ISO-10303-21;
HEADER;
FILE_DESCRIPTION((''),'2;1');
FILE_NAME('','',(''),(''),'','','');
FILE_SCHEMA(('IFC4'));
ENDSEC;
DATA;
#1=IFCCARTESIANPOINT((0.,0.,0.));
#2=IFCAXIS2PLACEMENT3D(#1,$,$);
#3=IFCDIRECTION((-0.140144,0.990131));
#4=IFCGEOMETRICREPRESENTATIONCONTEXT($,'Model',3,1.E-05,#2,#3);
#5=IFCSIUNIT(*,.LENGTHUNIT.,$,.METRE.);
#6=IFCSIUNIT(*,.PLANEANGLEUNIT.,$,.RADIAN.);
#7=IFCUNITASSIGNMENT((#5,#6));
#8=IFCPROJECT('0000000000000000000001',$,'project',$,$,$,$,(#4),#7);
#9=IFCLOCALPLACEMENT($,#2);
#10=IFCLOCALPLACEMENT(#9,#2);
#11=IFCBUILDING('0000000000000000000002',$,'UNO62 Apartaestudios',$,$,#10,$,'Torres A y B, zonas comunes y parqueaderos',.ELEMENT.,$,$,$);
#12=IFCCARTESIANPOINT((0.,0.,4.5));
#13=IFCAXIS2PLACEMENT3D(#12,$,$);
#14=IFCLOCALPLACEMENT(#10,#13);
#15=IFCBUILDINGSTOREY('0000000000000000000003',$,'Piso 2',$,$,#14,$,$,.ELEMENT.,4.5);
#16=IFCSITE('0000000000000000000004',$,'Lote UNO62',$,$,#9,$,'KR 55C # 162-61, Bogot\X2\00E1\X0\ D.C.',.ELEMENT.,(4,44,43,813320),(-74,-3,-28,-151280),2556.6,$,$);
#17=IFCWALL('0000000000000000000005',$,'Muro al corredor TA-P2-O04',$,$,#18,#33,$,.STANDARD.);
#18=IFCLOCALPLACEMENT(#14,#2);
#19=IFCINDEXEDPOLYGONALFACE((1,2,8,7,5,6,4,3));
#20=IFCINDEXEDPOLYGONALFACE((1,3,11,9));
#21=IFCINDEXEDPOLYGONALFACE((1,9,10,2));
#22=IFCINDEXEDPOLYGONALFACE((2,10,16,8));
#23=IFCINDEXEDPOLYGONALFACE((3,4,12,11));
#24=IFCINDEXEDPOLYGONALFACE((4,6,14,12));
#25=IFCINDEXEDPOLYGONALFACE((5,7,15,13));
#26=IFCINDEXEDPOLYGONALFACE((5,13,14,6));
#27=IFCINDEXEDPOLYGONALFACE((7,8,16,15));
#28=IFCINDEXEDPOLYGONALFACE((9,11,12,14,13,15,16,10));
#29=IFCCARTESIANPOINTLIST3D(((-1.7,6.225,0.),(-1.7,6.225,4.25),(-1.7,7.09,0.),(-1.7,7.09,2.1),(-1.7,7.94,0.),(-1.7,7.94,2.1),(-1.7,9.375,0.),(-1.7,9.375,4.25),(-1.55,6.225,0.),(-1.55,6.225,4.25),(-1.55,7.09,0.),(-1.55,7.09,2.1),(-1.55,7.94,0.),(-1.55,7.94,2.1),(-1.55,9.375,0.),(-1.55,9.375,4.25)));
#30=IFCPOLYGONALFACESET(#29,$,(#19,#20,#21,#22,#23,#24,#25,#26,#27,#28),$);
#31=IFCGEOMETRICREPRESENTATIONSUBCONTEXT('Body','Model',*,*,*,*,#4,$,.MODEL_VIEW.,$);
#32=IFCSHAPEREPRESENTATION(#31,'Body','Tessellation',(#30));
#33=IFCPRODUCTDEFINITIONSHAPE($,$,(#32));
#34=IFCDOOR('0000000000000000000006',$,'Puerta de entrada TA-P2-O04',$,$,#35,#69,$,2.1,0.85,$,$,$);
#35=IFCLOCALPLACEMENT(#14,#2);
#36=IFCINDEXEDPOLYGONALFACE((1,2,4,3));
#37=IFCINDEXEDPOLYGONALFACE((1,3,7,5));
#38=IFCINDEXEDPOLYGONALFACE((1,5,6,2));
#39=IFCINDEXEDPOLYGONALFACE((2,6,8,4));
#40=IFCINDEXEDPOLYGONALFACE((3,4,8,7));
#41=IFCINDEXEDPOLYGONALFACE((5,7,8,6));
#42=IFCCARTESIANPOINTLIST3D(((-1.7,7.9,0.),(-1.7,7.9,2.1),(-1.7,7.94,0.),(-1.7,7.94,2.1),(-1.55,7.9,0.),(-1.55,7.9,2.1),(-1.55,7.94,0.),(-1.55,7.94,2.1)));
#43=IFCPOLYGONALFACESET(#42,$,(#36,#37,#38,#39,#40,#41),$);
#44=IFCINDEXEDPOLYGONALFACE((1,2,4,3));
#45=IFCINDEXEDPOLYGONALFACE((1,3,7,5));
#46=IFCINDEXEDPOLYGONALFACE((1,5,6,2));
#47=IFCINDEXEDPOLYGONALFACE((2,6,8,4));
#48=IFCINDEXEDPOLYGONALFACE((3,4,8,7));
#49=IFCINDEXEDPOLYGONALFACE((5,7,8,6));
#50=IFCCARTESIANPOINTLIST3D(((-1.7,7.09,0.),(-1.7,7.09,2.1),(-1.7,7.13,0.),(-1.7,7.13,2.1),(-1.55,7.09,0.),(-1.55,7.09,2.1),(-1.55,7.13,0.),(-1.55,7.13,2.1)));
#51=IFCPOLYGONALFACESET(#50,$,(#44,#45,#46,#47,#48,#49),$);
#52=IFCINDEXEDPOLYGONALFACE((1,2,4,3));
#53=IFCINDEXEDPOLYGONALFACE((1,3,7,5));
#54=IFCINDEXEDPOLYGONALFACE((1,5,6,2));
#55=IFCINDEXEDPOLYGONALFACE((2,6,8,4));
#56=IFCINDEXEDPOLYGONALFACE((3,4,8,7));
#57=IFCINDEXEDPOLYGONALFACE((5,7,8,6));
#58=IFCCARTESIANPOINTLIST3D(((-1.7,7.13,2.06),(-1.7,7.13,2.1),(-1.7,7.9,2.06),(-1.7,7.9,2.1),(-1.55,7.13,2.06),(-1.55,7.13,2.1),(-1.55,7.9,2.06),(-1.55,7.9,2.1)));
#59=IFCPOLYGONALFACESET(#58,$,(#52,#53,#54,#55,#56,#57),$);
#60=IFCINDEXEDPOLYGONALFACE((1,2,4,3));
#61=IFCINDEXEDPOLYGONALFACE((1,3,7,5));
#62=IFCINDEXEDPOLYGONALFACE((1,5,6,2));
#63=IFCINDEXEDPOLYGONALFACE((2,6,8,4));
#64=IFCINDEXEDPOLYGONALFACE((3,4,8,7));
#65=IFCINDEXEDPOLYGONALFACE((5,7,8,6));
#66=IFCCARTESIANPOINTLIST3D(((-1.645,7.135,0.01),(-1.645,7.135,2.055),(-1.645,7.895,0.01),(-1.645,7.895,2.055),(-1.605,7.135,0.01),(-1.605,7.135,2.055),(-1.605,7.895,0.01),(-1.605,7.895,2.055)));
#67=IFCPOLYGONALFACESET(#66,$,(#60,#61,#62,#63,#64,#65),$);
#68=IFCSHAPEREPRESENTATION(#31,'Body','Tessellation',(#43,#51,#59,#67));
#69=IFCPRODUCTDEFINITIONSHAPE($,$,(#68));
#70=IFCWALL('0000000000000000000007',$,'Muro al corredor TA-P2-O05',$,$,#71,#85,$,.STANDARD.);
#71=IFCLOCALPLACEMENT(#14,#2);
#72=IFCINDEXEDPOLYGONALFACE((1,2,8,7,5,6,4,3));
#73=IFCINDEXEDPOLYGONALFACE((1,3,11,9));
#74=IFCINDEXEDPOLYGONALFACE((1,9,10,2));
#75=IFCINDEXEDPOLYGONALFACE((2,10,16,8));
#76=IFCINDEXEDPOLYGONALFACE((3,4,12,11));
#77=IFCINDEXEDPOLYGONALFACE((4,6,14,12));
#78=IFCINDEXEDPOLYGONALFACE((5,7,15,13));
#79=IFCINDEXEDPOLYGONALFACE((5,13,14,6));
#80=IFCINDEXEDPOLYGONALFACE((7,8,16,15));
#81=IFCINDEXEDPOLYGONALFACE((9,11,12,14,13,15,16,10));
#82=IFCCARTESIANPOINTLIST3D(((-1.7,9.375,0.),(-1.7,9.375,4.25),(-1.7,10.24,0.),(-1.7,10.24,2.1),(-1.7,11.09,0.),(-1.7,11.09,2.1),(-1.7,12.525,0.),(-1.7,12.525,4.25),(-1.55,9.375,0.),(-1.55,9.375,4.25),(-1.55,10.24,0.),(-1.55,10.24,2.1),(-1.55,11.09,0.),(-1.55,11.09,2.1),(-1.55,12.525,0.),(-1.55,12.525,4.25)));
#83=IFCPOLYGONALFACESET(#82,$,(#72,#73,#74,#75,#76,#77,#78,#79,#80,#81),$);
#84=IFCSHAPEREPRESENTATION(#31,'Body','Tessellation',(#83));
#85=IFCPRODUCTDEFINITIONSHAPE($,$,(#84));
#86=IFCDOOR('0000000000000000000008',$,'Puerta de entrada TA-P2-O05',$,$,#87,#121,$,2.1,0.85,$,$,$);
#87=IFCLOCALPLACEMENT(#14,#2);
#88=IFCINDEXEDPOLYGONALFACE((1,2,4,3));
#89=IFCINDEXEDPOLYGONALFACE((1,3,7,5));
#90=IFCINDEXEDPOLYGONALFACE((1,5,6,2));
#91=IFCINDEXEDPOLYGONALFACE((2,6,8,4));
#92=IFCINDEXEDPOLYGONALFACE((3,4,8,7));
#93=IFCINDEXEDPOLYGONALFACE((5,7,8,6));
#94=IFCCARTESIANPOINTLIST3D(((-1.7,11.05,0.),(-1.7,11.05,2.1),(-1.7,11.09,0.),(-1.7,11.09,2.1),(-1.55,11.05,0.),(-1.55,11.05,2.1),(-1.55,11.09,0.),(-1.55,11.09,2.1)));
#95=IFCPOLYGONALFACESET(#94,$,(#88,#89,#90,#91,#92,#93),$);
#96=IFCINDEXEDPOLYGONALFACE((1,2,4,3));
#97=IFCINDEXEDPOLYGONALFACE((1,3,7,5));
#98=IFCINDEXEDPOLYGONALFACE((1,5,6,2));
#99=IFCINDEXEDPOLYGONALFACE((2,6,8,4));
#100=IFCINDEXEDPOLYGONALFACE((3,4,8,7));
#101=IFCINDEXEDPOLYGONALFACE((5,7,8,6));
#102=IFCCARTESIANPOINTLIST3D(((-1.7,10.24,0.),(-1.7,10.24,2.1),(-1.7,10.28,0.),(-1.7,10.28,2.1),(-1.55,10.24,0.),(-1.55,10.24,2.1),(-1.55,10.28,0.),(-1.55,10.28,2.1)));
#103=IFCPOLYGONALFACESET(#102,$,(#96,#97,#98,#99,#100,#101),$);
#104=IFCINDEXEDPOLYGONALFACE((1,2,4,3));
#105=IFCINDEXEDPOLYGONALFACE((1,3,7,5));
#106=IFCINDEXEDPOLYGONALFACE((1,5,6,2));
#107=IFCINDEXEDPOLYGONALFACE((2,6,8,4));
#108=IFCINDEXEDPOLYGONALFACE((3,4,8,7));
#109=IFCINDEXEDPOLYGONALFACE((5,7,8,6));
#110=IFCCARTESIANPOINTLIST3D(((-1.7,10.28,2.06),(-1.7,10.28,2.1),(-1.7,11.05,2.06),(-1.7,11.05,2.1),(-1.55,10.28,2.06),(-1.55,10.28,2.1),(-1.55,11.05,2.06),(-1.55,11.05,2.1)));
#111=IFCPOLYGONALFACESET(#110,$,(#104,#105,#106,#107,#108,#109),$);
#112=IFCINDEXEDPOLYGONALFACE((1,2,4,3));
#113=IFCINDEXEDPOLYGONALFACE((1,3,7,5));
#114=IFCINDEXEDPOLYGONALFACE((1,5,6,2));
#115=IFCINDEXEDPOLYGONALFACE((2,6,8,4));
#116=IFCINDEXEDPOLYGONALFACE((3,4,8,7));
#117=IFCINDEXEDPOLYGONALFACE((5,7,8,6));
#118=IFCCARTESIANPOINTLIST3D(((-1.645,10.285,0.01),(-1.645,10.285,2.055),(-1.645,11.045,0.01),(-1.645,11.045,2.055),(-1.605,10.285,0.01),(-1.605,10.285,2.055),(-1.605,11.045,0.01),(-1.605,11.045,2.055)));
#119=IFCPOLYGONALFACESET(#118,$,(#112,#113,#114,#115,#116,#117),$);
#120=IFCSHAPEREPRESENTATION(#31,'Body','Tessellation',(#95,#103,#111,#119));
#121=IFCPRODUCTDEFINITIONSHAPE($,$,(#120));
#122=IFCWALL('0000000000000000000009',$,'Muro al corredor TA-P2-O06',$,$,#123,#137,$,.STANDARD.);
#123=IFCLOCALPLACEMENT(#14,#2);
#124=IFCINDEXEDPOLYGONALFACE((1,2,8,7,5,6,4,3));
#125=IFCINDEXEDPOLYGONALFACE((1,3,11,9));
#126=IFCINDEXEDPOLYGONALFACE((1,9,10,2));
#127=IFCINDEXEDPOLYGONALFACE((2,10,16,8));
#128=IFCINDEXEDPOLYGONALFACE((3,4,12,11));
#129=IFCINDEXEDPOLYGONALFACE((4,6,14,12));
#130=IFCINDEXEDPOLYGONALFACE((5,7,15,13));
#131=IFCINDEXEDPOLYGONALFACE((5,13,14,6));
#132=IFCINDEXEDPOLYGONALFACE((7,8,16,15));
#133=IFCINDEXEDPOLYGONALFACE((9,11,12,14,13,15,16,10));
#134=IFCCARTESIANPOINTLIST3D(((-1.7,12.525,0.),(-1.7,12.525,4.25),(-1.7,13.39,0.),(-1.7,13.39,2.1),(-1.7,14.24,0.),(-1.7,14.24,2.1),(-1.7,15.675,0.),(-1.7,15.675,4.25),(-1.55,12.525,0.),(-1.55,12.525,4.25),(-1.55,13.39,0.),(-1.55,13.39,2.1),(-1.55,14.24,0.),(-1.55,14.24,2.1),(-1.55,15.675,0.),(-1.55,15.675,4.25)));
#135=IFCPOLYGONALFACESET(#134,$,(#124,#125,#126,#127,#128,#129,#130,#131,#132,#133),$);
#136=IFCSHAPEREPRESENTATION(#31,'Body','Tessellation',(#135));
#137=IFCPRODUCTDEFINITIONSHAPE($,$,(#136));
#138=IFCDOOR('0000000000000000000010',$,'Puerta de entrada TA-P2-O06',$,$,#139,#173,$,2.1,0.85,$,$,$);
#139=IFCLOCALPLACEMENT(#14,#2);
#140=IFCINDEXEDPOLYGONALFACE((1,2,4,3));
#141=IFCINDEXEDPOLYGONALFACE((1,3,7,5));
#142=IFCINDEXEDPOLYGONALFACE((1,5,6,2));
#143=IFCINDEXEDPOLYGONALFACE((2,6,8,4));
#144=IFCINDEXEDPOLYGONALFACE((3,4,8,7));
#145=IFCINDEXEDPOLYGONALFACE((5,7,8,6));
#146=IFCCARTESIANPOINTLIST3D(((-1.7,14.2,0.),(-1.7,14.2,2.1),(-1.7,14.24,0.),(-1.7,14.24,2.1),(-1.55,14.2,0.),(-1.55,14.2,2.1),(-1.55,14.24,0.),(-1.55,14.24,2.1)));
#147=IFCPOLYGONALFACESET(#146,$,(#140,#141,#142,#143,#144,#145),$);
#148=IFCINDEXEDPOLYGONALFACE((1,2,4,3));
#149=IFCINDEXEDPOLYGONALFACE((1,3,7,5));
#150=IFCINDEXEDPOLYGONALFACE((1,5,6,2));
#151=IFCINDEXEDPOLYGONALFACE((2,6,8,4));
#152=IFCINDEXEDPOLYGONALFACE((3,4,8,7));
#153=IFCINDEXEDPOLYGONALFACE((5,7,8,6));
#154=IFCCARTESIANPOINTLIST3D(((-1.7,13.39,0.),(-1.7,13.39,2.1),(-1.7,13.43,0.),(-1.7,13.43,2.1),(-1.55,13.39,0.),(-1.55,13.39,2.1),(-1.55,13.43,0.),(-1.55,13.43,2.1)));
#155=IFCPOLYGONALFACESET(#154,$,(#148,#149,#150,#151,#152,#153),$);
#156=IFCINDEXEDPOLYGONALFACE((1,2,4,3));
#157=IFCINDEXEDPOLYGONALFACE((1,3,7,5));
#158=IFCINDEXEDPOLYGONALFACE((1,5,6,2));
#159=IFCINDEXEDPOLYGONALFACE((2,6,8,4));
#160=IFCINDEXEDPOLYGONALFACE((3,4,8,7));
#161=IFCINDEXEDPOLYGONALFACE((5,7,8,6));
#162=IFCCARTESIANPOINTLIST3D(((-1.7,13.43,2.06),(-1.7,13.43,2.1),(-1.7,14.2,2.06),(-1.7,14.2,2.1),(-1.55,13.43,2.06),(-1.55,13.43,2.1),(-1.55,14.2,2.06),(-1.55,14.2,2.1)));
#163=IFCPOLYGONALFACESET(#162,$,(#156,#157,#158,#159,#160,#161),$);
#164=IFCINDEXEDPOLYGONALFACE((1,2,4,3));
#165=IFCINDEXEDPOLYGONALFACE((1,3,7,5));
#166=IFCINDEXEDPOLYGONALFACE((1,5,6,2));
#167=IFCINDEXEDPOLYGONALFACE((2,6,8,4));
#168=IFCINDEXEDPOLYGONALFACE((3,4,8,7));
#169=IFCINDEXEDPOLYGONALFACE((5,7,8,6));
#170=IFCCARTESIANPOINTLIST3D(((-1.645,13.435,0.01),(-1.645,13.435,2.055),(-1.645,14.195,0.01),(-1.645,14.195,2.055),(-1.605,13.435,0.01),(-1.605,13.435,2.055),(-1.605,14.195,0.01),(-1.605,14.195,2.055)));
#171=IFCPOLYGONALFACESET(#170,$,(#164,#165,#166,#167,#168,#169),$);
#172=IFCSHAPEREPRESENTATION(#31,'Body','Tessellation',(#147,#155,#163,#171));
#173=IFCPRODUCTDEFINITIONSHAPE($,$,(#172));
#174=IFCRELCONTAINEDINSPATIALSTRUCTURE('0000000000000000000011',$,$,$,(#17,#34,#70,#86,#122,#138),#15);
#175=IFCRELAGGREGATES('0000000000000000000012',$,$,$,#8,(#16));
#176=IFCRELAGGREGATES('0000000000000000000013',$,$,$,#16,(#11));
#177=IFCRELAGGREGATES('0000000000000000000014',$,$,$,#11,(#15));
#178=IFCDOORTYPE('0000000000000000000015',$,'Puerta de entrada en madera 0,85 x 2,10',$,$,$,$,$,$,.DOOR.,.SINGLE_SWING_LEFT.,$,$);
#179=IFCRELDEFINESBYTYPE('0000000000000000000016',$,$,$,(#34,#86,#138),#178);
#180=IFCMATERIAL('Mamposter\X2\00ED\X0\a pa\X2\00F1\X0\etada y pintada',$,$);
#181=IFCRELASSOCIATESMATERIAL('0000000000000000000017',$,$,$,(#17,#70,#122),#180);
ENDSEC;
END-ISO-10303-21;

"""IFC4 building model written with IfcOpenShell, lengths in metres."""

from ifc_helpers import new_model, si_unit, direction, frame, frame_2d, origin, place, context, subcontext, project, spatial, rectangle, extrude, source, transform, mapped, material, type_object, type_shapes, element, fill, save


model = new_model("IFC4")

# Units and contexts
model_context = context("Model", 3, precision=1e-05, world=origin(), true_north=direction((-0.140144, 0.990131)))
body_context = subcontext(model_context, "Body", "Model", "MODEL_VIEW")
ifc_project = project(units=[si_unit("LENGTHUNIT", "METRE"), si_unit("PLANEANGLEUNIT", "RADIAN")], contexts=[model_context])

# Site, building, storey
site_placement = place(None, origin())
site = spatial("IfcSite", under=ifc_project, at=site_placement, Name="Lote UNO62", LongName="KR 55C # 162-61, Bogotá D.C.", CompositionType="ELEMENT", RefLatitude=(4, 44, 43, 813320), RefLongitude=(-74, -3, -28, -151280), RefElevation=2556.6)
building_placement = place(site_placement, origin())
building = spatial("IfcBuilding", under=site, at=building_placement, Name="UNO62 Apartaestudios", LongName="Torres A y B, zonas comunes y parqueaderos", CompositionType="ELEMENT")
storey_placement = place(building_placement, frame((0.0, 0.0, 4.5)))
storey = spatial("IfcBuildingStorey", under=building, at=storey_placement, Name="Piso 2", CompositionType="ELEMENT", Elevation=4.5)

# Walls, openings, doors
ifc_material = material(Name="Mampostería pañetada y pintada")
wall_1_placement = place(storey_placement, origin())
wall_1 = element("IfcWall", 1, at=wall_1_placement, inside=storey, material=ifc_material, Name="Muro al corredor TA-P2-O04", PredefinedType="STANDARD", context=body_context, shape_type="SweptSolid", body=[
    extrude(rectangle(XDim=0.15, YDim=3.15, at=frame_2d((-1.625, 7.8))), origin(), (0.0, 0.0, 1.0), 4.25),
])
opening_1_placement = place(wall_1_placement, origin())
opening_1 = element("IfcOpeningElement", 2, at=opening_1_placement, cuts=wall_1, PredefinedType="OPENING", context=body_context, shape_type="SweptSolid", body=[
    extrude(rectangle(XDim=0.25, YDim=0.85, at=frame_2d((-1.625, 7.515))), origin(), (0.0, 0.0, 1.0), 2.1),
])
door_type = type_object("IfcDoorType", Name="Puerta de entrada en madera 0,85 x 2,10", OperationType="SINGLE_SWING_LEFT", PredefinedType="DOOR")
shared_shape = source(origin(), body_context, "Body", "SweptSolid", [
    extrude(rectangle(XDim=0.15, YDim=0.04, at=frame_2d((-0.075, 1.38))), origin(), (0.0, 0.0, 1.0), 2.1),
    extrude(rectangle(XDim=0.15, YDim=0.04, at=frame_2d((-0.075, 2.19))), origin(), (0.0, 0.0, 1.0), 2.1),
    extrude(rectangle(XDim=0.15, YDim=0.77, at=frame_2d((-0.075, 1.785))), frame((0.0, 0.0, 2.06)), (0.0, 0.0, 1.0), 0.04),
    extrude(rectangle(XDim=0.04, YDim=0.76, at=frame_2d((-0.075, 1.785))), frame((0.0, 0.0, 0.01)), (0.0, 0.0, 1.0), 2.045),
])
type_shapes(door_type, [shared_shape])
placement_1 = place(storey_placement, frame((-1.7, 9.3, 0.0), z_axis=(0.0, 0.0, 1.0), x_axis=(-1.0, 0.0, 0.0)))
door_1_placement = place(placement_1, origin())
door_1 = element("IfcDoor", 3, at=door_1_placement, inside=storey, type_object=door_type, Name="Puerta de entrada TA-P2-O04", OverallHeight=2.1, OverallWidth=0.85, context=body_context, shape_type="MappedRepresentation", body=[
    mapped(shared_shape, transform((0.0, 0.0, 0.0))),
])
fill(opening_1, door_1)
wall_2_placement = place(storey_placement, origin())
wall_2 = element("IfcWall", 4, at=wall_2_placement, inside=storey, material=ifc_material, Name="Muro al corredor TA-P2-O05", PredefinedType="STANDARD", context=body_context, shape_type="SweptSolid", body=[
    extrude(rectangle(XDim=0.15, YDim=3.15, at=frame_2d((-1.625, 10.95))), origin(), (0.0, 0.0, 1.0), 4.25),
])
opening_2_placement = place(wall_2_placement, origin())
opening_2 = element("IfcOpeningElement", 5, at=opening_2_placement, cuts=wall_2, PredefinedType="OPENING", context=body_context, shape_type="SweptSolid", body=[
    extrude(rectangle(XDim=0.25, YDim=0.85, at=frame_2d((-1.625, 10.665))), origin(), (0.0, 0.0, 1.0), 2.1),
])
placement_2 = place(storey_placement, frame((-1.7, 12.45, 0.0), z_axis=(0.0, 0.0, 1.0), x_axis=(-1.0, 0.0, 0.0)))
door_2_placement = place(placement_2, origin())
door_2 = element("IfcDoor", 6, at=door_2_placement, inside=storey, type_object=door_type, Name="Puerta de entrada TA-P2-O05", OverallHeight=2.1, OverallWidth=0.85, context=body_context, shape_type="MappedRepresentation", body=[
    mapped(shared_shape, transform((0.0, 0.0, 0.0))),
])
fill(opening_2, door_2)
wall_3_placement = place(storey_placement, origin())
wall_3 = element("IfcWall", 7, at=wall_3_placement, inside=storey, material=ifc_material, Name="Muro al corredor TA-P2-O06", PredefinedType="STANDARD", context=body_context, shape_type="SweptSolid", body=[
    extrude(rectangle(XDim=0.15, YDim=3.15, at=frame_2d((-1.625, 14.1))), origin(), (0.0, 0.0, 1.0), 4.25),
])
opening_3_placement = place(wall_3_placement, origin())
opening_3 = element("IfcOpeningElement", 8, at=opening_3_placement, cuts=wall_3, PredefinedType="OPENING", context=body_context, shape_type="SweptSolid", body=[
    extrude(rectangle(XDim=0.25, YDim=0.85, at=frame_2d((-1.625, 13.815))), origin(), (0.0, 0.0, 1.0), 2.1),
])
placement_3 = place(storey_placement, frame((-1.7, 15.6, 0.0), z_axis=(0.0, 0.0, 1.0), x_axis=(-1.0, 0.0, 0.0)))
door_3_placement = place(placement_3, origin())
door_3 = element("IfcDoor", 9, at=door_3_placement, inside=storey, type_object=door_type, Name="Puerta de entrada TA-P2-O06", OverallHeight=2.1, OverallWidth=0.85, context=body_context, shape_type="MappedRepresentation", body=[
    mapped(shared_shape, transform((0.0, 0.0, 0.0))),
])
fill(opening_3, door_3)

save(model, "model.ifc")
